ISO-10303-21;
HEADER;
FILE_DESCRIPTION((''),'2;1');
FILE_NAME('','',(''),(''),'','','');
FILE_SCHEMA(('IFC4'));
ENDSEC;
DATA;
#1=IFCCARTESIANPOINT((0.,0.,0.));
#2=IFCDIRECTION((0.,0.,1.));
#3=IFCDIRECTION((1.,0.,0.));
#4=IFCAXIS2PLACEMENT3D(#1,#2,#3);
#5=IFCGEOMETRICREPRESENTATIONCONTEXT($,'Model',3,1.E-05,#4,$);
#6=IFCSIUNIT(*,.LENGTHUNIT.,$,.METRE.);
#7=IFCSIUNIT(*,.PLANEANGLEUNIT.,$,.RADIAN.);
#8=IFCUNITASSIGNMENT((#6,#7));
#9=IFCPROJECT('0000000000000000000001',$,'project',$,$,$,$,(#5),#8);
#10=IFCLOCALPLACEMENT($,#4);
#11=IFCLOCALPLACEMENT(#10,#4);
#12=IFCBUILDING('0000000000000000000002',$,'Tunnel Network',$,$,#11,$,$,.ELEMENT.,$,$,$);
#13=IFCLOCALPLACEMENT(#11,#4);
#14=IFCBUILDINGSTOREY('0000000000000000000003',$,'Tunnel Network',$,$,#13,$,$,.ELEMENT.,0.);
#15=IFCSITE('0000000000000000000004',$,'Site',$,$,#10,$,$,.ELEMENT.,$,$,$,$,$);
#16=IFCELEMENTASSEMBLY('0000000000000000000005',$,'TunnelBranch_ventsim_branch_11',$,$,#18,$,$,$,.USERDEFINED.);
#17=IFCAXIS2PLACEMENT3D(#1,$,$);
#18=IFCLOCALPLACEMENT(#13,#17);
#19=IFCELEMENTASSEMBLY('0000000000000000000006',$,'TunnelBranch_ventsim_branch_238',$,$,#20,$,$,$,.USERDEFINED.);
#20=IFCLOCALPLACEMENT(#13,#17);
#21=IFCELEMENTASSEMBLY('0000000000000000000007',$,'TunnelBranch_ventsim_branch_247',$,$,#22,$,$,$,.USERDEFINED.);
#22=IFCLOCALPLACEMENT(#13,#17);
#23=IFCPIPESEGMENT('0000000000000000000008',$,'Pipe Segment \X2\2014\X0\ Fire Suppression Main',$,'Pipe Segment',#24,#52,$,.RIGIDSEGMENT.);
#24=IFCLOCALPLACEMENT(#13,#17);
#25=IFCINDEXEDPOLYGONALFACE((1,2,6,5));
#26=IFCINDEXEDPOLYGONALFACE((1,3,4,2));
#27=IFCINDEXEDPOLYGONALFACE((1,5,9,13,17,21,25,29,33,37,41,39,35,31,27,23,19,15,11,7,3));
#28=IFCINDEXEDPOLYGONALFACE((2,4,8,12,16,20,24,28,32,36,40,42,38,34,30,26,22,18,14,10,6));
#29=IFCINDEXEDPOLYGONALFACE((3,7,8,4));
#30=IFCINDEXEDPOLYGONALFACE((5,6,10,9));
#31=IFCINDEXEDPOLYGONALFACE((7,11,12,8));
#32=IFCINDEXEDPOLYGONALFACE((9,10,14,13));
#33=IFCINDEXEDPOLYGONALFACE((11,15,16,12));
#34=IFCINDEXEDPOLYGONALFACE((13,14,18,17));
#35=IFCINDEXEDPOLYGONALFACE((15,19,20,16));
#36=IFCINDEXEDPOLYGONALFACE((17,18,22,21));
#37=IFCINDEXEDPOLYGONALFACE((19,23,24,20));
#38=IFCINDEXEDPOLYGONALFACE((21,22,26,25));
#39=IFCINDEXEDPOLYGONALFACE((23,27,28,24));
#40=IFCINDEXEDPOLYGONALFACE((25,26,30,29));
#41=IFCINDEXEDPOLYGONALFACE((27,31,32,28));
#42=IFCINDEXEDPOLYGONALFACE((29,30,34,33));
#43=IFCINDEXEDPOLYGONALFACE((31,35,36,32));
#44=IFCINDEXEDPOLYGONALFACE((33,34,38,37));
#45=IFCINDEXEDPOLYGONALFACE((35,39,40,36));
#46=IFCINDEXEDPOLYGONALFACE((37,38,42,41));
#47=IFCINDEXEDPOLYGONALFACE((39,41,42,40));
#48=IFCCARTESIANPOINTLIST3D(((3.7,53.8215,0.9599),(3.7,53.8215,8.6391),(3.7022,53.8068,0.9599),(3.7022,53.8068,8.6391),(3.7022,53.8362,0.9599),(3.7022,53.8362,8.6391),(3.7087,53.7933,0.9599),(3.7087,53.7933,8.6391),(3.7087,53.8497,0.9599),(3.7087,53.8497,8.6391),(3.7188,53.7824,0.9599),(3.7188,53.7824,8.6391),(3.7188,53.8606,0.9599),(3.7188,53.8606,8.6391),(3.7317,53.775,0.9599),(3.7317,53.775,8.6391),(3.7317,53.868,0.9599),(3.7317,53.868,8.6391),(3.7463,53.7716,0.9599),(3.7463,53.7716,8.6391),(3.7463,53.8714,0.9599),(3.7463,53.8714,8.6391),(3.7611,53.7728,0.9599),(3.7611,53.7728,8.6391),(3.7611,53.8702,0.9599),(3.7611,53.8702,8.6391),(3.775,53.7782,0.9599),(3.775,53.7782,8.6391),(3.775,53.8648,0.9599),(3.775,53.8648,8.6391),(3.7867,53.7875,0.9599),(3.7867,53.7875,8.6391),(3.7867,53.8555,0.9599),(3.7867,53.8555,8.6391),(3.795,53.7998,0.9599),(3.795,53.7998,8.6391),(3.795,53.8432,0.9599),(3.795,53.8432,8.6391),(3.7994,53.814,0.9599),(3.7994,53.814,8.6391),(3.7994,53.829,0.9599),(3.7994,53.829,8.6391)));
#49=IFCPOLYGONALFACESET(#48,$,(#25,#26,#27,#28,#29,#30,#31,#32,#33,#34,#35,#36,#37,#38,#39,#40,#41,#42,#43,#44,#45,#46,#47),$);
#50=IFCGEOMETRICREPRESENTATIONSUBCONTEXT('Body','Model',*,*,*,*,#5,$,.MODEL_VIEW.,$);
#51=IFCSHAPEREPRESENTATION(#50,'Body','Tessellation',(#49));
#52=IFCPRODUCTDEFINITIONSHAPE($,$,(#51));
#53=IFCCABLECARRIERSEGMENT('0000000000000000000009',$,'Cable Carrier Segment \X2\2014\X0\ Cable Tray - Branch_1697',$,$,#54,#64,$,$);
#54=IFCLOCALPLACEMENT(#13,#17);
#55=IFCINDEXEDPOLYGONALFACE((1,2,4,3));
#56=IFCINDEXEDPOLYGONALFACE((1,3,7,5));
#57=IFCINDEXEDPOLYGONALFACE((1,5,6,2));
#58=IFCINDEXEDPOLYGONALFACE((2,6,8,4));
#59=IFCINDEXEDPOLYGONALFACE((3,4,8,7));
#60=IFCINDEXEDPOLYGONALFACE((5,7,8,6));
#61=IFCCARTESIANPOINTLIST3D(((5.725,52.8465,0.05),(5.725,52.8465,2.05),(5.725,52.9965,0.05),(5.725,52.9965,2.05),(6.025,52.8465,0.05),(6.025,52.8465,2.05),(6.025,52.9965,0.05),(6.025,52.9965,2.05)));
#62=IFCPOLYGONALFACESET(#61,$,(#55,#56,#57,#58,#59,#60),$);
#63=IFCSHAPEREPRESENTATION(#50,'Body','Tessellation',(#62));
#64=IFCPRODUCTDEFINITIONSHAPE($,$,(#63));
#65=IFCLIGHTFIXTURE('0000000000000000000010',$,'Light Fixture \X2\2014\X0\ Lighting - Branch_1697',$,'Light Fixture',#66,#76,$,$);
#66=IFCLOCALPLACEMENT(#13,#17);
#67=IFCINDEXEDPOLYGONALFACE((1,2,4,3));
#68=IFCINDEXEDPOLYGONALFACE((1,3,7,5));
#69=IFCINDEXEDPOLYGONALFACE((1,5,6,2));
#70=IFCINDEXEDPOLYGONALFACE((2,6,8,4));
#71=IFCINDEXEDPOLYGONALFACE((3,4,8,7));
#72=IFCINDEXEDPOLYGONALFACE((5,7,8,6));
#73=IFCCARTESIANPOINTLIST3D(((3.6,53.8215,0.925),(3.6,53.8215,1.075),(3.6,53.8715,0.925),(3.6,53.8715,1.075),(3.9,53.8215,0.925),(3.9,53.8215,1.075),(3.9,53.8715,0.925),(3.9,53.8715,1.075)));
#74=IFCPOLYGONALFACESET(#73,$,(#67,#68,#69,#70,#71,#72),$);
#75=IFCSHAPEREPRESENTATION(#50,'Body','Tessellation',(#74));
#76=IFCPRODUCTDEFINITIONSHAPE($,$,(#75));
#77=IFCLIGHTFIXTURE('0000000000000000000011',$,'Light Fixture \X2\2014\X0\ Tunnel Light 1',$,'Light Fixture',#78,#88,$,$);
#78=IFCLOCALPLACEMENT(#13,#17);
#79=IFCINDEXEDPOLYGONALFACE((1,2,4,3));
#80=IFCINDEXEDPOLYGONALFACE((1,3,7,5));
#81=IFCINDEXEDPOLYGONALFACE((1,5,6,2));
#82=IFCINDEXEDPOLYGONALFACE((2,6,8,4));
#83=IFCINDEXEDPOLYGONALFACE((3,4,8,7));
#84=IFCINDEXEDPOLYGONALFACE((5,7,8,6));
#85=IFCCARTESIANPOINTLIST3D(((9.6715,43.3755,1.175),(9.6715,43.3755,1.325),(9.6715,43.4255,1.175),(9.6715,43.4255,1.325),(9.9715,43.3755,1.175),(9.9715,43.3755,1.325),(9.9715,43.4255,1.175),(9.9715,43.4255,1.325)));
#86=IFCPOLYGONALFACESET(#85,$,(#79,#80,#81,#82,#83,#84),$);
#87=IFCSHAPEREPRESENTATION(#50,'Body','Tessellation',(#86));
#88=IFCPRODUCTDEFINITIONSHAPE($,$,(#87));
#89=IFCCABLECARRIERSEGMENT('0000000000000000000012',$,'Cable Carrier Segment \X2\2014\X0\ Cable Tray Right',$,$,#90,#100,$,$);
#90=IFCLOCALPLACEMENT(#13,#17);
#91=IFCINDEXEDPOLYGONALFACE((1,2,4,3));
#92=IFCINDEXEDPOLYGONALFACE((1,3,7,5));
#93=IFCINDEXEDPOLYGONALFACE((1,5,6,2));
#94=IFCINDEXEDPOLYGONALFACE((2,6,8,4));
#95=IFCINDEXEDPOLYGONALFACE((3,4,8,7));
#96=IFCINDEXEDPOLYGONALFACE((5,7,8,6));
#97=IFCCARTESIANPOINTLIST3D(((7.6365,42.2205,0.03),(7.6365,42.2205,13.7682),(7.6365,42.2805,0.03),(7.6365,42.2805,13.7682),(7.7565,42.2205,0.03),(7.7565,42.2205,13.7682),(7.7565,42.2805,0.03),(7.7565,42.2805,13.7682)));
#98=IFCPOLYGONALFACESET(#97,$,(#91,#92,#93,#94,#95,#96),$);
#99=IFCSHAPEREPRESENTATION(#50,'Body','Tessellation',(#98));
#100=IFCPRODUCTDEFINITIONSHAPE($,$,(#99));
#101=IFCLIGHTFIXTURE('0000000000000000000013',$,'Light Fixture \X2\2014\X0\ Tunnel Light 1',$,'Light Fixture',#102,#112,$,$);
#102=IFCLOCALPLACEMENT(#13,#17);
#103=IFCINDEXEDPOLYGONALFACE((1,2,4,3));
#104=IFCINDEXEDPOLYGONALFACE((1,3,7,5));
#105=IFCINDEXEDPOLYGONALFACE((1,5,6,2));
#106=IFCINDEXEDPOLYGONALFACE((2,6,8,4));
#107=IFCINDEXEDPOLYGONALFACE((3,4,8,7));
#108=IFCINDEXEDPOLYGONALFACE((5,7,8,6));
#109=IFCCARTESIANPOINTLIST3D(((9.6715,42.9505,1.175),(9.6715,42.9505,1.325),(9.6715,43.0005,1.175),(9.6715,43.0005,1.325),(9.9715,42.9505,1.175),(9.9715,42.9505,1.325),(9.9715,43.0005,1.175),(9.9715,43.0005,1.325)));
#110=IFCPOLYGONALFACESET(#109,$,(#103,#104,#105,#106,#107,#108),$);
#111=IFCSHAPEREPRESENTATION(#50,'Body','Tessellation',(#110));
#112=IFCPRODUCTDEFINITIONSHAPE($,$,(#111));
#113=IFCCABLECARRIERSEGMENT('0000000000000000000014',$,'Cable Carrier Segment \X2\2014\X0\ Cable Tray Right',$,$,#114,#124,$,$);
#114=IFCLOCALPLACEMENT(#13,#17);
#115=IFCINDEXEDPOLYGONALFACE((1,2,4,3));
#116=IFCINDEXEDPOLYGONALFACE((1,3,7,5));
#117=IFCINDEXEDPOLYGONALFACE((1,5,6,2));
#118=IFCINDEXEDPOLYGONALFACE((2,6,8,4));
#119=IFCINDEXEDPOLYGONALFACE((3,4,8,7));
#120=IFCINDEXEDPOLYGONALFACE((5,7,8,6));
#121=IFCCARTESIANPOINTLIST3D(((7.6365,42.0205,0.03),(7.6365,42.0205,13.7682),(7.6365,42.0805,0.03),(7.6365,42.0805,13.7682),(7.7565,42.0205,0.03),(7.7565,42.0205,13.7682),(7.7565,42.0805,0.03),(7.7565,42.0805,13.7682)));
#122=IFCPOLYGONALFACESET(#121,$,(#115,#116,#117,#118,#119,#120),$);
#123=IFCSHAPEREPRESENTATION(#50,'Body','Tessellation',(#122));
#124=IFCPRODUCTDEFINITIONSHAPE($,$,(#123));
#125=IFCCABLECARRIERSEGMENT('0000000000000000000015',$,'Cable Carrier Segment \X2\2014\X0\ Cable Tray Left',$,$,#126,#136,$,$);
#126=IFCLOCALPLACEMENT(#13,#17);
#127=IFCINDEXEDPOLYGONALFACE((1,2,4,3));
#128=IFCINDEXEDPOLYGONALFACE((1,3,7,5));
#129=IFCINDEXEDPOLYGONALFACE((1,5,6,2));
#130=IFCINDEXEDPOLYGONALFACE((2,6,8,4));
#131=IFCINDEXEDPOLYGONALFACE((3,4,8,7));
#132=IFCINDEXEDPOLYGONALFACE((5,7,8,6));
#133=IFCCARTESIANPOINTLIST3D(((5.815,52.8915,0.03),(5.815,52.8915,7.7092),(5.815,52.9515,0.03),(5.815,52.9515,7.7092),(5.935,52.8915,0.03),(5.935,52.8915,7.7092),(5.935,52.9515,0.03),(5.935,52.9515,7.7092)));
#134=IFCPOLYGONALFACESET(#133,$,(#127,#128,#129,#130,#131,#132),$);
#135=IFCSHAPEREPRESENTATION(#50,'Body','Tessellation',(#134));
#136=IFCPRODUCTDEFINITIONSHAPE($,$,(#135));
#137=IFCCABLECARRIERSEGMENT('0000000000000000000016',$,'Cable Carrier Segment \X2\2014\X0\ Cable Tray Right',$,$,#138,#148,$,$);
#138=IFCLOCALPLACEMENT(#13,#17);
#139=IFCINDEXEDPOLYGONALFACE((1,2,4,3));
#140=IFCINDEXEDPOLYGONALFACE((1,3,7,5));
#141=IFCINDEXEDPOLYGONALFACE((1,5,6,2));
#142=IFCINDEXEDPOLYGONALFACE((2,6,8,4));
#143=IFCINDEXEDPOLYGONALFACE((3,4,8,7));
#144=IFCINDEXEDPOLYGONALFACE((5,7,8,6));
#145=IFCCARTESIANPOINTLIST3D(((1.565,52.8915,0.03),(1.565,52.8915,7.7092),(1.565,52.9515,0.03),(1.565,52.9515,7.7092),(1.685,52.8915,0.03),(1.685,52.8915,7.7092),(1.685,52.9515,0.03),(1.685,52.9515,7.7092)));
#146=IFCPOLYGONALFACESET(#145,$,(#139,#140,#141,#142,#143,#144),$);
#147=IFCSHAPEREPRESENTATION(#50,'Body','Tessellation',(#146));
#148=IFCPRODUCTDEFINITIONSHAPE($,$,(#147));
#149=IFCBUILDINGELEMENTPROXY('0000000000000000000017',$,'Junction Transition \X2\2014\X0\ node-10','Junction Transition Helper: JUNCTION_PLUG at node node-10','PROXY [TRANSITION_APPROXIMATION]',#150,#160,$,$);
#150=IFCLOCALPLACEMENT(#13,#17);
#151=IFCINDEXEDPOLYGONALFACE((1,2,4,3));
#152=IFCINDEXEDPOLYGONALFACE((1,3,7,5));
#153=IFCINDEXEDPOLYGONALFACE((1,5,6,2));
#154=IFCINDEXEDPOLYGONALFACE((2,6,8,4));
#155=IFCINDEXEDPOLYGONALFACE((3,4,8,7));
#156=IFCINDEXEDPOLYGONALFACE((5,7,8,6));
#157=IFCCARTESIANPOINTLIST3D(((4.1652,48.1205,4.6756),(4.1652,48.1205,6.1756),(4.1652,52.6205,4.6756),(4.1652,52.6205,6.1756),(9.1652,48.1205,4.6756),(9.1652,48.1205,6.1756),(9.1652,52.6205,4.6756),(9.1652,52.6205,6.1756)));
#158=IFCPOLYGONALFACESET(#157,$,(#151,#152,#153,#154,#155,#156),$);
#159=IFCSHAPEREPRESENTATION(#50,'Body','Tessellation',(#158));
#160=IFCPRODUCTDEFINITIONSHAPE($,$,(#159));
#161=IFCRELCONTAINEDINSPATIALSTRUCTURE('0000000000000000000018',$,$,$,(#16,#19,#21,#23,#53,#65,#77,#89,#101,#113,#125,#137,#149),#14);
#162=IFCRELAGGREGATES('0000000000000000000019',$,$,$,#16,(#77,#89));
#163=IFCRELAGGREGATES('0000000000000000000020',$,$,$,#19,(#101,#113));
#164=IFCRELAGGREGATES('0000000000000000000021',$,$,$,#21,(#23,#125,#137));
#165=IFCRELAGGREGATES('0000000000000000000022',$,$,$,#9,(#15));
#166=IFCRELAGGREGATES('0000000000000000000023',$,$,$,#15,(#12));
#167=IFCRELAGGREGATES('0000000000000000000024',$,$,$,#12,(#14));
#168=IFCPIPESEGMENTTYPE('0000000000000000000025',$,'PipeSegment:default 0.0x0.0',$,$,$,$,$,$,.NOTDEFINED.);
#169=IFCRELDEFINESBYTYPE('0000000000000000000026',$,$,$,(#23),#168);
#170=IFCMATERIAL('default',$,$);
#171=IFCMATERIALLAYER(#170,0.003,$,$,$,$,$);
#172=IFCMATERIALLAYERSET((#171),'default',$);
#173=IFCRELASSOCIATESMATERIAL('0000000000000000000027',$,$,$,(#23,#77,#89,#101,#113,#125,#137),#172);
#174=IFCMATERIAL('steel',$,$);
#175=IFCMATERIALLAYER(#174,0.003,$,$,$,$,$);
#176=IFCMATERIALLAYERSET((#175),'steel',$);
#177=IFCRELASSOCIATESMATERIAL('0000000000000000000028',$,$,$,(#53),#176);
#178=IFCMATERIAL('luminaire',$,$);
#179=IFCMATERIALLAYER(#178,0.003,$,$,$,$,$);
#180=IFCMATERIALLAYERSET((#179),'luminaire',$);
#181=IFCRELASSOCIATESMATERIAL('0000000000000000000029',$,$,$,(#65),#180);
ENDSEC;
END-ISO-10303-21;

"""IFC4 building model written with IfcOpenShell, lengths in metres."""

from ifc_helpers import new_model, si_unit, frame, origin_with_axes, origin_2d_with_axis, place, context, subcontext, project, spatial, rectangle, circle, extrude, material, layer, layer_set, layer_usage, type_object, element, aggregate, save


model = new_model("IFC4")

# Units and contexts
model_context = context("Model", 3, precision=1e-05, world=origin_with_axes())
body_context = subcontext(model_context, "Body", "Model", "MODEL_VIEW")
ifc_project = project(units=[si_unit("LENGTHUNIT", "METRE"), si_unit("PLANEANGLEUNIT", "RADIAN")], contexts=[model_context])

# Site, building, storey
site_placement = place(None, origin_with_axes())
site = spatial("IfcSite", under=ifc_project, at=site_placement, Name="Site", CompositionType="ELEMENT")
building_placement = place(site_placement, origin_with_axes())
building = spatial("IfcBuilding", under=site, at=building_placement, Name="Tunnel Network", CompositionType="ELEMENT")
storey_placement = place(building_placement, origin_with_axes())
storey = spatial("IfcBuildingStorey", under=building, at=storey_placement, Name="Tunnel Network", CompositionType="ELEMENT", Elevation=0.0)

# Element assemblies, pipe segment
assembly_1_placement = place(storey_placement, frame((9.8215, 43.3755, 1.25), z_axis=(0.0, 1.0, 0.0), x_axis=(-1.0, 0.0, 0.0)))
assembly_1 = element("IfcElementAssembly", 1, at=assembly_1_placement, inside=storey, Name="TunnelBranch_ventsim_branch_11", PredefinedType="USERDEFINED")
ifc_material_1 = material(Name="default")
ifc_layer_1 = layer(ifc_material_1, 0.003)
ifc_layer_set_1 = layer_set([ifc_layer_1], Name="default")
pipe_segment_type = type_object("IfcPipeSegmentType", Name="PipeSegment:default 0.0x0.0")
assembly_2_placement = place(storey_placement, frame((9.8215, 42.9505, 1.25), z_axis=(0.0, 1.0, 0.0), x_axis=(-1.0, 0.0, 0.0)))
assembly_2 = element("IfcElementAssembly", 2, at=assembly_2_placement, inside=storey, Name="TunnelBranch_ventsim_branch_238", PredefinedType="USERDEFINED")
assembly_3_placement = place(storey_placement, frame((3.75, 53.8215, 0.9599), z_axis=(0.0, 0.0, 1.0), x_axis=(-1.0, 0.0, 0.0)))
assembly_3 = element("IfcElementAssembly", 3, at=assembly_3_placement, inside=storey, Name="TunnelBranch_ventsim_branch_247", PredefinedType="USERDEFINED")
ifc_layer_usage_1 = layer_usage(ifc_layer_set_1, "AXIS2", "POSITIVE", 0.0)
pipe_segment_1_placement = place(storey_placement, frame((3.75, 53.8215, 0.9599), z_axis=(0.0, 0.0, 1.0), x_axis=(-1.0, 0.0, 0.0)))
pipe_segment_1 = element("IfcPipeSegment", 4, at=pipe_segment_1_placement, inside=storey, type_object=pipe_segment_type, material=ifc_layer_usage_1, Name="Pipe Segment — Fire Suppression Main", ObjectType="Pipe Segment", PredefinedType="RIGIDSEGMENT", context=body_context, shape_type="SweptSolid", body=[
    extrude(circle(Radius=0.05, at=origin_2d_with_axis()), origin_with_axes(), (0.0, 0.0, 1.0), 7.6792),
])

# Cable carrier segment
ifc_material_2 = material(Name="steel")
ifc_layer_2 = layer(ifc_material_2, 0.003)
ifc_layer_set_2 = layer_set([ifc_layer_2], Name="steel")
ifc_layer_usage_2 = layer_usage(ifc_layer_set_2, "AXIS2", "POSITIVE", 0.0)
cable_carrier_segment_1_placement = place(storey_placement, frame((5.875, 52.9215, 0.05), z_axis=(0.0, 0.0, 1.0), x_axis=(-1.0, 0.0, 0.0)))
element("IfcCableCarrierSegment", 5, at=cable_carrier_segment_1_placement, inside=storey, material=ifc_layer_usage_2, Name="Cable Carrier Segment — Cable Tray - Branch_1697", context=body_context, shape_type="SweptSolid", body=[
    extrude(rectangle(XDim=0.3, YDim=0.15, at=origin_2d_with_axis()), origin_with_axes(), (0.0, 0.0, 1.0), 2.0),
])

# Light fixture
ifc_material_3 = material(Name="luminaire")
ifc_layer_3 = layer(ifc_material_3, 0.003)
ifc_layer_set_3 = layer_set([ifc_layer_3], Name="luminaire")
ifc_layer_usage_3 = layer_usage(ifc_layer_set_3, "AXIS2", "POSITIVE", 0.0)
light_fixture_1_placement = place(storey_placement, frame((3.75, 53.8215, 1.0), z_axis=(0.0, 1.0, 0.0), x_axis=(-1.0, 0.0, 0.0)))
element("IfcLightFixture", 6, at=light_fixture_1_placement, inside=storey, material=ifc_layer_usage_3, Name="Light Fixture — Lighting - Branch_1697", ObjectType="Light Fixture", context=body_context, shape_type="SweptSolid", body=[
    extrude(rectangle(XDim=0.3, YDim=0.15, at=origin_2d_with_axis()), origin_with_axes(), (0.0, 0.0, 1.0), 0.05),
])

# Light fixture
ifc_layer_usage_4 = layer_usage(ifc_layer_set_1, "AXIS2", "POSITIVE", 0.0)
light_fixture_2_placement = place(storey_placement, frame((9.8215, 43.3755, 1.25), z_axis=(0.0, 1.0, 0.0), x_axis=(-1.0, 0.0, 0.0)))
light_fixture_2 = element("IfcLightFixture", 7, at=light_fixture_2_placement, inside=storey, material=ifc_layer_usage_4, Name="Light Fixture — Tunnel Light 1", ObjectType="Light Fixture", context=body_context, shape_type="SweptSolid", body=[
    extrude(rectangle(XDim=0.3, YDim=0.15, at=origin_2d_with_axis()), origin_with_axes(), (0.0, 0.0, 1.0), 0.05),
])

# Cable carrier segment
ifc_layer_usage_5 = layer_usage(ifc_layer_set_1, "AXIS2", "POSITIVE", 0.0)
cable_carrier_segment_2_placement = place(storey_placement, frame((7.6965, 42.2505, 0.03), z_axis=(0.0, 0.0, 1.0), x_axis=(-1.0, 0.0, 0.0)))
cable_carrier_segment_2 = element("IfcCableCarrierSegment", 8, at=cable_carrier_segment_2_placement, inside=storey, material=ifc_layer_usage_5, Name="Cable Carrier Segment — Cable Tray Right", context=body_context, shape_type="SweptSolid", body=[
    extrude(rectangle(XDim=0.12, YDim=0.06, at=origin_2d_with_axis()), origin_with_axes(), (0.0, 0.0, 1.0), 13.7382),
])
aggregate(assembly_1, [light_fixture_2, cable_carrier_segment_2])

# Light fixture
ifc_layer_usage_6 = layer_usage(ifc_layer_set_1, "AXIS2", "POSITIVE", 0.0)
light_fixture_3_placement = place(storey_placement, frame((9.8215, 42.9505, 1.25), z_axis=(0.0, 1.0, 0.0), x_axis=(-1.0, 0.0, 0.0)))
light_fixture_3 = element("IfcLightFixture", 9, at=light_fixture_3_placement, inside=storey, material=ifc_layer_usage_6, Name="Light Fixture — Tunnel Light 1", ObjectType="Light Fixture", context=body_context, shape_type="SweptSolid", body=[
    extrude(rectangle(XDim=0.3, YDim=0.15, at=origin_2d_with_axis()), origin_with_axes(), (0.0, 0.0, 1.0), 0.05),
])

# Cable carrier segments
ifc_layer_usage_7 = layer_usage(ifc_layer_set_1, "AXIS2", "POSITIVE", 0.0)
cable_carrier_segment_3_placement = place(storey_placement, frame((7.6965, 42.0505, 0.03), z_axis=(0.0, 0.0, 1.0), x_axis=(-1.0, 0.0, 0.0)))
cable_carrier_segment_3 = element("IfcCableCarrierSegment", 10, at=cable_carrier_segment_3_placement, inside=storey, material=ifc_layer_usage_7, Name="Cable Carrier Segment — Cable Tray Right", context=body_context, shape_type="SweptSolid", body=[
    extrude(rectangle(XDim=0.12, YDim=0.06, at=origin_2d_with_axis()), origin_with_axes(), (0.0, 0.0, 1.0), 13.7382),
])
aggregate(assembly_2, [light_fixture_3, cable_carrier_segment_3])
ifc_layer_usage_8 = layer_usage(ifc_layer_set_1, "AXIS2", "POSITIVE", 0.0)
cable_carrier_segment_4_placement = place(storey_placement, frame((5.875, 52.9215, 0.03), z_axis=(0.0, 0.0, 1.0), x_axis=(-1.0, 0.0, 0.0)))
cable_carrier_segment_4 = element("IfcCableCarrierSegment", 11, at=cable_carrier_segment_4_placement, inside=storey, material=ifc_layer_usage_8, Name="Cable Carrier Segment — Cable Tray Left", context=body_context, shape_type="SweptSolid", body=[
    extrude(rectangle(XDim=0.12, YDim=0.06, at=origin_2d_with_axis()), origin_with_axes(), (0.0, 0.0, 1.0), 7.6792),
])
ifc_layer_usage_9 = layer_usage(ifc_layer_set_1, "AXIS2", "POSITIVE", 0.0)
cable_carrier_segment_5_placement = place(storey_placement, frame((1.625, 52.9215, 0.03), z_axis=(0.0, 0.0, 1.0), x_axis=(-1.0, 0.0, 0.0)))
cable_carrier_segment_5 = element("IfcCableCarrierSegment", 12, at=cable_carrier_segment_5_placement, inside=storey, material=ifc_layer_usage_9, Name="Cable Carrier Segment — Cable Tray Right", context=body_context, shape_type="SweptSolid", body=[
    extrude(rectangle(XDim=0.12, YDim=0.06, at=origin_2d_with_axis()), origin_with_axes(), (0.0, 0.0, 1.0), 7.6792),
])
aggregate(assembly_3, [pipe_segment_1, cable_carrier_segment_4, cable_carrier_segment_5])

# Building element proxy
proxy_placement = place(storey_placement, frame((6.6652, 50.3705, 4.6756), z_axis=(0.0, 0.0, 1.0), x_axis=(1.0, 0.0, 0.0)))
element("IfcBuildingElementProxy", 13, at=proxy_placement, inside=storey, Name="Junction Transition — node-10", Description="Junction Transition Helper: JUNCTION_PLUG at node node-10", ObjectType="PROXY [TRANSITION_APPROXIMATION]", context=body_context, shape_type="SweptSolid", body=[
    extrude(rectangle(XDim=5.0, YDim=4.5, at=origin_2d_with_axis()), origin_with_axes(), (0.0, 0.0, 1.0), 1.5),
])

save(model, "model.ifc")
